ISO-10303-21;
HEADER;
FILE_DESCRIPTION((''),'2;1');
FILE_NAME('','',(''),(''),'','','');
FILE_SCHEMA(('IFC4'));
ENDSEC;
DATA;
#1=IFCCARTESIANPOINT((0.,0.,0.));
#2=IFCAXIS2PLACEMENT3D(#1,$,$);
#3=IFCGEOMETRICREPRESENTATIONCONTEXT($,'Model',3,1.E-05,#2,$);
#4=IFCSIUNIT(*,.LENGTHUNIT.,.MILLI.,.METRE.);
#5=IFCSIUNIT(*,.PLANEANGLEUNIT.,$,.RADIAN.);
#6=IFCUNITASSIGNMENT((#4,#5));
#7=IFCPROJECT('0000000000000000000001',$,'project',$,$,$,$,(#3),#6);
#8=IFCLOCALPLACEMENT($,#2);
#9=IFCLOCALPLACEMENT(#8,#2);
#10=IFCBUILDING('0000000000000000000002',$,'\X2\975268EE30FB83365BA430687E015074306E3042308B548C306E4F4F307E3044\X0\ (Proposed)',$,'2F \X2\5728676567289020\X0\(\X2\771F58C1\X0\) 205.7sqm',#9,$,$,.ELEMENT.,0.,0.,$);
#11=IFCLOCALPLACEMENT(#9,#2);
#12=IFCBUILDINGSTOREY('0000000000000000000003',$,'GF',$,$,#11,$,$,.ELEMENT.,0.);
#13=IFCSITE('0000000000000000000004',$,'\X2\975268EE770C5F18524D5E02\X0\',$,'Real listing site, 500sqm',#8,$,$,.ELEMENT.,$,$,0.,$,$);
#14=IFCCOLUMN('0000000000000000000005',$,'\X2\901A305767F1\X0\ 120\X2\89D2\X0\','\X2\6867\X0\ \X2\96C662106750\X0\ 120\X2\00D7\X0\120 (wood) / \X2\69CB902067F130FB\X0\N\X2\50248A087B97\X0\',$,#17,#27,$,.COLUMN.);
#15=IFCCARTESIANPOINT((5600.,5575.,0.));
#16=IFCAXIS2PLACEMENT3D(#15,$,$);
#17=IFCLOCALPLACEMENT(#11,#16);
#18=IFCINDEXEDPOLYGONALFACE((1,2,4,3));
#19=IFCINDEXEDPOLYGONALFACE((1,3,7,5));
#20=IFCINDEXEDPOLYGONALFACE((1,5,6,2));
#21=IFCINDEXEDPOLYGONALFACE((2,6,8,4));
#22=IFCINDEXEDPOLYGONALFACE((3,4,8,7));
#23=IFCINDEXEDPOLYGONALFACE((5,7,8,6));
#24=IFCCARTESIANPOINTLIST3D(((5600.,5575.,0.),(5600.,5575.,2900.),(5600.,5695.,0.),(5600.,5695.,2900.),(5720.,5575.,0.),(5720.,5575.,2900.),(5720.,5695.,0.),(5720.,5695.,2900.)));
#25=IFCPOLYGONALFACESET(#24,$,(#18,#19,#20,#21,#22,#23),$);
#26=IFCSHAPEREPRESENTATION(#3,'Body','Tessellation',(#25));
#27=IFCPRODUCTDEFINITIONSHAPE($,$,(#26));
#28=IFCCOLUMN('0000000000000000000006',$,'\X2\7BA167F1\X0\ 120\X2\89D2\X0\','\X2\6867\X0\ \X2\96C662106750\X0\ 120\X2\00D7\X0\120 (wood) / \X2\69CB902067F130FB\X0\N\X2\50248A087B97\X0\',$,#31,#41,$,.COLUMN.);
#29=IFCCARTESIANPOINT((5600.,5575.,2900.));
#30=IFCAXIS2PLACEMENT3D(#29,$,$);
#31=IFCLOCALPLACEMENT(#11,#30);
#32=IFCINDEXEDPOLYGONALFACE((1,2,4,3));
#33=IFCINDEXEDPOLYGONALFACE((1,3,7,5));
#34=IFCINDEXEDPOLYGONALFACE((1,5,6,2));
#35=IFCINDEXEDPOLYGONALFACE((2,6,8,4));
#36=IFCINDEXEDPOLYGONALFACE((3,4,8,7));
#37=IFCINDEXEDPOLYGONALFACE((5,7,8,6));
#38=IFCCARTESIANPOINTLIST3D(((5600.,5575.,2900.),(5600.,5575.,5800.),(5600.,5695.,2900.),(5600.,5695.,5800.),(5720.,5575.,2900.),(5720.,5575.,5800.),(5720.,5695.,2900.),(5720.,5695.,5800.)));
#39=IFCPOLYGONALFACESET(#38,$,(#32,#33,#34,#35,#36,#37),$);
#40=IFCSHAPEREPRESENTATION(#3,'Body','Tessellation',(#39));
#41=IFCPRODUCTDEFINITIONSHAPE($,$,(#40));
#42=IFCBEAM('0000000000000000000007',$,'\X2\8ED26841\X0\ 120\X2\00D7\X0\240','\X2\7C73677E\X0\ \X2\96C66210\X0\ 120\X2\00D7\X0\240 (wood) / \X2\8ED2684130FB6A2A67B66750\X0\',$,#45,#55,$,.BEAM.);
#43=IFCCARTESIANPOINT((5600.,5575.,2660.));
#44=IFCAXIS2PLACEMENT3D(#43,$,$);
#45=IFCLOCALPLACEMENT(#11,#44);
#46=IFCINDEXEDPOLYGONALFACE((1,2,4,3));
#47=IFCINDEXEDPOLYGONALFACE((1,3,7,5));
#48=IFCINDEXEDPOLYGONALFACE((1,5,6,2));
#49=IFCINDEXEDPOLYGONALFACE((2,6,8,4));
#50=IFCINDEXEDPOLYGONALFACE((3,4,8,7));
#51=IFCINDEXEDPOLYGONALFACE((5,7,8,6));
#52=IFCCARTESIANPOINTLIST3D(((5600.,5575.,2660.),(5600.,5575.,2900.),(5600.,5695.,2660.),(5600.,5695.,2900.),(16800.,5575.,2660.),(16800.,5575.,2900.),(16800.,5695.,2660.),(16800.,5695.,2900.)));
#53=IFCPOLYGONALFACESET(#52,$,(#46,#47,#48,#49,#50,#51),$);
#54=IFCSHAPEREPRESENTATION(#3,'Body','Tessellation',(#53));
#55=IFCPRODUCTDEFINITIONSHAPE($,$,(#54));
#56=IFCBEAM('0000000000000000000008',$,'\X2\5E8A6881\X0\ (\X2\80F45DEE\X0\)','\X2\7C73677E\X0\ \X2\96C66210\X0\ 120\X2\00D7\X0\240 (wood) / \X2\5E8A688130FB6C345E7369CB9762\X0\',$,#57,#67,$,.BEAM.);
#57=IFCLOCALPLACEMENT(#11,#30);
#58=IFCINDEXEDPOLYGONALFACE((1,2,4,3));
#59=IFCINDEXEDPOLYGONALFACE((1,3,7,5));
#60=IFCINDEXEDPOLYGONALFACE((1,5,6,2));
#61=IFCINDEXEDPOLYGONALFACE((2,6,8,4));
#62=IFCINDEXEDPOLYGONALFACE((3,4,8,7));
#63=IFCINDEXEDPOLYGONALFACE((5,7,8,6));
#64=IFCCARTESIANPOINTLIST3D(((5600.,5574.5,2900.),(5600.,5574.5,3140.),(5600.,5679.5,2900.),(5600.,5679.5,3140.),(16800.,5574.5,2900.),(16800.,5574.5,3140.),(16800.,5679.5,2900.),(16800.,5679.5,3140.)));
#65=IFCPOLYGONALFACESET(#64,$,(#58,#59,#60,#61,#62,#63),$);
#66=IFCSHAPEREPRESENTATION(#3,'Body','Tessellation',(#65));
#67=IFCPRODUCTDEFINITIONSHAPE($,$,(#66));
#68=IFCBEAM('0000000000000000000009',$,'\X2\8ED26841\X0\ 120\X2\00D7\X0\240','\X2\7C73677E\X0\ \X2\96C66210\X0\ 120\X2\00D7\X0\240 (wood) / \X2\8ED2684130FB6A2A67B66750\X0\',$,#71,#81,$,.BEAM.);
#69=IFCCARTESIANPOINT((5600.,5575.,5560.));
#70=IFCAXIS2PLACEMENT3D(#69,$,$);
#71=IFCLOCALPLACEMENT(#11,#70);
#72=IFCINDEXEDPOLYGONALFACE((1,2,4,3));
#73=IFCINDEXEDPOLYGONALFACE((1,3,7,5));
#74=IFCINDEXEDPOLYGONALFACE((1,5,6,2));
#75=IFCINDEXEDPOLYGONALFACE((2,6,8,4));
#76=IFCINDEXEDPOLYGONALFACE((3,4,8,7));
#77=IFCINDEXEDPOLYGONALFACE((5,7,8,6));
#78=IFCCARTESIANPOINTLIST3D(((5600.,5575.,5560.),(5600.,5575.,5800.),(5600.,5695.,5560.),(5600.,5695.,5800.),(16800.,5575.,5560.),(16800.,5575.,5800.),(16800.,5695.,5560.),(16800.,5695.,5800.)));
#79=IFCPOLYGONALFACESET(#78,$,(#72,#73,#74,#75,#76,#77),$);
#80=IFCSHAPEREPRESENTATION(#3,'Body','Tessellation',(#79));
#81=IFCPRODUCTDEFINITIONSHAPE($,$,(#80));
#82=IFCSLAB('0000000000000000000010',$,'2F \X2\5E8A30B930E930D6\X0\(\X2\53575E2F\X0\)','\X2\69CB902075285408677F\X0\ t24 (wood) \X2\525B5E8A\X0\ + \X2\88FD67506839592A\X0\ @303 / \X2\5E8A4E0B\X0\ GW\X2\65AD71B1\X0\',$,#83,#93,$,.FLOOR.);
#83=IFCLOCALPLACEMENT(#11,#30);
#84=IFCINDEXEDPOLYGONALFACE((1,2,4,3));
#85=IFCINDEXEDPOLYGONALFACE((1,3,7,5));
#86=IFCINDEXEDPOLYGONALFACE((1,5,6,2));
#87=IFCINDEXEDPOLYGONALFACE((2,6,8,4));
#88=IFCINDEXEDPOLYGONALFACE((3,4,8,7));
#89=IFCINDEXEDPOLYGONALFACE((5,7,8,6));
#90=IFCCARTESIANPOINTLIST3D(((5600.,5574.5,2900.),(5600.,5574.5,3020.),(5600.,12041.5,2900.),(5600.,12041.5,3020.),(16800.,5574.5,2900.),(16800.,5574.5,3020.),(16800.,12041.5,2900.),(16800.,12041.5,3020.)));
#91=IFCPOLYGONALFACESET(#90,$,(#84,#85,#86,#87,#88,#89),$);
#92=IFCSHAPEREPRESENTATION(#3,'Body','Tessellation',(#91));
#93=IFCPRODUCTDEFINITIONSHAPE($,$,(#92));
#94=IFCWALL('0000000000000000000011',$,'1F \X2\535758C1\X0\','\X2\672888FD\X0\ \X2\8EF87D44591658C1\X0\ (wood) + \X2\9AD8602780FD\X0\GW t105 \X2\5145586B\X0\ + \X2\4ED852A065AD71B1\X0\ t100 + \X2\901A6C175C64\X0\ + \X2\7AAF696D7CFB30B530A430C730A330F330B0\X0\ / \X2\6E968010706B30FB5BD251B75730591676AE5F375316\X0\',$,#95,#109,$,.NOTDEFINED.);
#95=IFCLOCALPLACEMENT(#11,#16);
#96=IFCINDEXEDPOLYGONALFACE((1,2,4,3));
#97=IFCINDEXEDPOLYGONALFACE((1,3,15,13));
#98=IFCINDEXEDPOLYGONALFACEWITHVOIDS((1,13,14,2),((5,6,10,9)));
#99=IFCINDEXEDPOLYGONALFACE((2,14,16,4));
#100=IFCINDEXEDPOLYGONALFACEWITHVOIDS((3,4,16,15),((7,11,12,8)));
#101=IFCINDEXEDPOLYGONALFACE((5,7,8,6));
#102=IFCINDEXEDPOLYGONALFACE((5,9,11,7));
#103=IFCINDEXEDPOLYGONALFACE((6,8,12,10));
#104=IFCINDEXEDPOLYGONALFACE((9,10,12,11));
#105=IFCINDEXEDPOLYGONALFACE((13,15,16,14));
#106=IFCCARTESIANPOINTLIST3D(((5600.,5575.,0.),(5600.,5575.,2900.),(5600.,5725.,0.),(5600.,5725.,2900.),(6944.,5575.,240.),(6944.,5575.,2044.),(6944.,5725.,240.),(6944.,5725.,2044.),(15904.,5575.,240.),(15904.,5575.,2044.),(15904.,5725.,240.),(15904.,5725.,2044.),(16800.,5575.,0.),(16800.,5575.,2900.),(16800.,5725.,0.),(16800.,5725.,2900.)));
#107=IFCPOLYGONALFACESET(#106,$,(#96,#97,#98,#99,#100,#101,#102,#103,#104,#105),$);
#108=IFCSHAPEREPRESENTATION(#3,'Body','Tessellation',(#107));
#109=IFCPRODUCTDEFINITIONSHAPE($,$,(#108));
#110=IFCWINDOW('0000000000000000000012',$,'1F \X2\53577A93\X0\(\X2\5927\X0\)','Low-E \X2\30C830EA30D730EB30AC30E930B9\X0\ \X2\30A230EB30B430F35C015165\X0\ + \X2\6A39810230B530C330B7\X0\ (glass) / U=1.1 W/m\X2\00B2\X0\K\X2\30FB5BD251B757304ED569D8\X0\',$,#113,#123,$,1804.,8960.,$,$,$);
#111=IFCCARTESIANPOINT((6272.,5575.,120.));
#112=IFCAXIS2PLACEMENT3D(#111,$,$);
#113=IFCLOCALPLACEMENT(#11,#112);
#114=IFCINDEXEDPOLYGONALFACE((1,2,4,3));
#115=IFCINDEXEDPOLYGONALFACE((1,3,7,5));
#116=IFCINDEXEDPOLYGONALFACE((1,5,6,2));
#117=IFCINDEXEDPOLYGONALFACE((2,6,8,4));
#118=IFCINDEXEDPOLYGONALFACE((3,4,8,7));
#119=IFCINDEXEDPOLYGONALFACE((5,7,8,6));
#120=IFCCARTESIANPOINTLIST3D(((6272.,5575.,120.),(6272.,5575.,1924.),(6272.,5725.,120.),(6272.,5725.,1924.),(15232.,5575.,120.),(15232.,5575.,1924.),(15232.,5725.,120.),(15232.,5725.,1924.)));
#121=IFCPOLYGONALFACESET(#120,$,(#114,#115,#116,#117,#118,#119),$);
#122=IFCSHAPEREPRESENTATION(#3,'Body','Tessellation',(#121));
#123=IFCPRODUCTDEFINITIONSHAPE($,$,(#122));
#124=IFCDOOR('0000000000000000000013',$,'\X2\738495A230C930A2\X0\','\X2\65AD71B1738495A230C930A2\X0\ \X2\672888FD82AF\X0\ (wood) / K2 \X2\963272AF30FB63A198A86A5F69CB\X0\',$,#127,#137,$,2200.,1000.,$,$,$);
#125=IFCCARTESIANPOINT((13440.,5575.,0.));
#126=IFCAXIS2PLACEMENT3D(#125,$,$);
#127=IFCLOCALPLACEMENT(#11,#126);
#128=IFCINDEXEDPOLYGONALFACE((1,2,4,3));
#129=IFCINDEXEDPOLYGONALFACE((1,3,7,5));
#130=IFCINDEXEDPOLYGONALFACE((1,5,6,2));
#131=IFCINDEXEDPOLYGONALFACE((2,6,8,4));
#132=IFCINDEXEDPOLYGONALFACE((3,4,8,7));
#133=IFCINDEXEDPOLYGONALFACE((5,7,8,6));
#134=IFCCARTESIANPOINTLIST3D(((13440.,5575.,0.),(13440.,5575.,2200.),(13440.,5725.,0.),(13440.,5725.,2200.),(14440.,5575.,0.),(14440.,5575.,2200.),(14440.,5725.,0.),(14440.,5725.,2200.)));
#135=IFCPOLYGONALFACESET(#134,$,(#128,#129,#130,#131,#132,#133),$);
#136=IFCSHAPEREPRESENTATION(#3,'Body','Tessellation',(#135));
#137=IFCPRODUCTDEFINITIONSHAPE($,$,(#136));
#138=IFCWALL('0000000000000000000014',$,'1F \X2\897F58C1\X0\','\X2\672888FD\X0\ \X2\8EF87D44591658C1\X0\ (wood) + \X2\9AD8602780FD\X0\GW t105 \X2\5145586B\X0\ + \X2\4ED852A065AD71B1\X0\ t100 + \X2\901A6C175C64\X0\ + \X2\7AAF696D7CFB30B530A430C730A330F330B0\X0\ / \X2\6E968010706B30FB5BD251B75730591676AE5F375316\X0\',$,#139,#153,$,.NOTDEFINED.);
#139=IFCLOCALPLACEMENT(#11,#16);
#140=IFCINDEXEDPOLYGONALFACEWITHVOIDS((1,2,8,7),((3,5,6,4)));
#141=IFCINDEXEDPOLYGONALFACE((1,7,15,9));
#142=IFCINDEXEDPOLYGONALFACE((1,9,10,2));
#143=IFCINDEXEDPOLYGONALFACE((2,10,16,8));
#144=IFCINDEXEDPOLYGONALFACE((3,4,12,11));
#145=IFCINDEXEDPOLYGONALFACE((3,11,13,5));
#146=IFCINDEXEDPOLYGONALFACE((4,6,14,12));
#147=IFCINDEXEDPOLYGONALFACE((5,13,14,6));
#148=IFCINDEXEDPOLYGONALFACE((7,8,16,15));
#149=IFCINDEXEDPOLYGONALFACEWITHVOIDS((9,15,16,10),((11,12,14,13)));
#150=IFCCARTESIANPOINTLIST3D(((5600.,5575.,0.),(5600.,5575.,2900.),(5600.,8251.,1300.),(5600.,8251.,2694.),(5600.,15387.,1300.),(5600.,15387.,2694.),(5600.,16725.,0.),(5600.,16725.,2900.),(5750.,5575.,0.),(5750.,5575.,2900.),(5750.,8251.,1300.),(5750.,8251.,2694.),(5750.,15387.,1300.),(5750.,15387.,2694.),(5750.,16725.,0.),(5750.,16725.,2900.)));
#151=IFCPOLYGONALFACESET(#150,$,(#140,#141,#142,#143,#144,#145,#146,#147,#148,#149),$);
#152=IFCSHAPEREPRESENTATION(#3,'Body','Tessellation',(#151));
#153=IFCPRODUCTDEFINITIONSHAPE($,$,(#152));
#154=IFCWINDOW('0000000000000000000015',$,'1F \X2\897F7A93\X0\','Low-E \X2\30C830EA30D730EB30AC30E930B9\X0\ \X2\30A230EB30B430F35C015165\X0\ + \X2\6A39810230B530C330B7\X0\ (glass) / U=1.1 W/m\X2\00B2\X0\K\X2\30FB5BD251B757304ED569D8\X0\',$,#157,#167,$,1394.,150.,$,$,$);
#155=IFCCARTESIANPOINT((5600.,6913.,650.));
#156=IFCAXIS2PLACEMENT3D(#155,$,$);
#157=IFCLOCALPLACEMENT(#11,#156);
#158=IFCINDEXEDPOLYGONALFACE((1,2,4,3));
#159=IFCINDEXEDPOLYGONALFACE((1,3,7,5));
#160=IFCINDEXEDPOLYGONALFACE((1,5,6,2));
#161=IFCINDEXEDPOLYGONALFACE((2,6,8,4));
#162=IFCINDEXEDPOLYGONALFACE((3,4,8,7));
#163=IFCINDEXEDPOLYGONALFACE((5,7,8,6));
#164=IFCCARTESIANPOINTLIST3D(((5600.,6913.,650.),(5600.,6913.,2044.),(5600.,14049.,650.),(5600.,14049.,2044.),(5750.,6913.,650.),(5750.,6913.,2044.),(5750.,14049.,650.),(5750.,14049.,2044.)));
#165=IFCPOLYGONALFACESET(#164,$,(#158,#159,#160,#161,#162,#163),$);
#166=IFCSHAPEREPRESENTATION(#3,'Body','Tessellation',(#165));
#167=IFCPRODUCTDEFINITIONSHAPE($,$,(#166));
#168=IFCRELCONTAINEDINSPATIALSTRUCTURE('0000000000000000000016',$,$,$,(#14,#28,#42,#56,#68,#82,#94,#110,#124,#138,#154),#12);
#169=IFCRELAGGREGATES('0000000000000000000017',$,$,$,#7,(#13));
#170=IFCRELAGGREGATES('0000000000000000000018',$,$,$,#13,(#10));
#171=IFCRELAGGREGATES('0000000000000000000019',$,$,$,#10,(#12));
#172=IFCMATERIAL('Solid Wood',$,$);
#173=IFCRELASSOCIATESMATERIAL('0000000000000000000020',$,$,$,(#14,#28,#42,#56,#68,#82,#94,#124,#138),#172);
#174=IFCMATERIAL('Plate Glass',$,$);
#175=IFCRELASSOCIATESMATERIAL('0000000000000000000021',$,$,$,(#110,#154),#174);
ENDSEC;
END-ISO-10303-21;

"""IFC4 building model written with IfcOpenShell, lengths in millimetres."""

from ifc_helpers import new_model, si_unit, frame, frame_2d, origin, place, context, project, spatial, rectangle, extrude, material, element, fill, save


model = new_model("IFC4")

# Units and contexts
model_context = context("Model", 3, precision=1e-05, world=origin())
ifc_project = project(units=[si_unit("LENGTHUNIT", "METRE", prefix="MILLI"), si_unit("PLANEANGLEUNIT", "RADIAN")], contexts=[model_context])

# Site, building, storey
site_placement = place(None, origin())
site = spatial("IfcSite", under=ifc_project, at=site_placement, Name="青森県弘前市", ObjectType="Real listing site, 500sqm", CompositionType="ELEMENT", RefElevation=0.0)
building_placement = place(site_placement, origin())
building = spatial("IfcBuilding", under=site, at=building_placement, Name="青森・茶室と縁側のある和の住まい (Proposed)", ObjectType="2F 在来木造(真壁) 205.7sqm", CompositionType="ELEMENT", ElevationOfRefHeight=0.0, ElevationOfTerrain=0.0)
storey_placement = place(building_placement, origin())
storey = spatial("IfcBuildingStorey", under=building, at=storey_placement, Name="GF", CompositionType="ELEMENT", Elevation=0.0)

# Columns
ifc_material_1 = material(Name="Solid Wood")
column_1_placement = place(storey_placement, frame((5600.0, 5575.0, 0.0)))
element("IfcColumn", 1, at=column_1_placement, inside=storey, material=ifc_material_1, Name="通し柱 120角", Description="桧 集成材 120×120 (wood) / 構造柱・N値計算", PredefinedType="COLUMN", context=model_context, shape_type="SweptSolid", body=[
    extrude(rectangle(XDim=120.0, YDim=120.0, at=frame_2d((60.0, 60.0))), frame((5600.0, 5575.0, 0.0)), (0.0, 0.0, 1.0), 2900.0),
])
column_2_placement = place(storey_placement, frame((5600.0, 5575.0, 2900.0)))
element("IfcColumn", 2, at=column_2_placement, inside=storey, material=ifc_material_1, Name="管柱 120角", Description="桧 集成材 120×120 (wood) / 構造柱・N値計算", PredefinedType="COLUMN", context=model_context, shape_type="SweptSolid", body=[
    extrude(rectangle(XDim=120.0, YDim=120.0, at=frame_2d((60.0, 60.0))), frame((5600.0, 5575.0, 2900.0)), (0.0, 0.0, 1.0), 2900.0),
])

# Beams
beam_1_placement = place(storey_placement, frame((5600.0, 5575.0, 2660.0)))
element("IfcBeam", 3, at=beam_1_placement, inside=storey, material=ifc_material_1, Name="軒桁 120×240", Description="米松 集成 120×240 (wood) / 軒桁・横架材", PredefinedType="BEAM", context=model_context, shape_type="SweptSolid", body=[
    extrude(rectangle(XDim=11200.0, YDim=120.0, at=frame_2d((5600.0, 60.0))), frame((5600.0, 5575.0, 2660.0)), (0.0, 0.0, 1.0), 240.0),
])
beam_2_placement = place(storey_placement, frame((5600.0, 5575.0, 2900.0)))
element("IfcBeam", 4, at=beam_2_placement, inside=storey, material=ifc_material_1, Name="床梁 (胴差)", Description="米松 集成 120×240 (wood) / 床梁・水平構面", PredefinedType="BEAM", context=model_context, shape_type="SweptSolid", body=[
    extrude(rectangle(XDim=11200.0, YDim=105.0, at=frame_2d((5600.0, 52.0))), frame((5600.0, 5575.0, 2900.0)), (0.0, 0.0, 1.0), 240.0),
])
beam_3_placement = place(storey_placement, frame((5600.0, 5575.0, 5560.0)))
element("IfcBeam", 5, at=beam_3_placement, inside=storey, material=ifc_material_1, Name="軒桁 120×240", Description="米松 集成 120×240 (wood) / 軒桁・横架材", PredefinedType="BEAM", context=model_context, shape_type="SweptSolid", body=[
    extrude(rectangle(XDim=11200.0, YDim=120.0, at=frame_2d((5600.0, 60.0))), frame((5600.0, 5575.0, 5560.0)), (0.0, 0.0, 1.0), 240.0),
])

# Slab
slab_1_placement = place(storey_placement, frame((5600.0, 5575.0, 2900.0)))
element("IfcSlab", 6, at=slab_1_placement, inside=storey, material=ifc_material_1, Name="2F 床スラブ(南帯)", Description="構造用合板 t24 (wood) 剛床 + 製材根太 @303 / 床下 GW断熱", PredefinedType="FLOOR", context=model_context, shape_type="SweptSolid", body=[
    extrude(rectangle(XDim=11200.0, YDim=6467.0, at=frame_2d((5600.0, 3233.0))), frame((5600.0, 5575.0, 2900.0)), (0.0, 0.0, 1.0), 120.0),
])

# Wall, openings, window, door
wall_1_placement = place(storey_placement, frame((5600.0, 5575.0, 0.0)))
wall_1 = element("IfcWall", 7, at=wall_1_placement, inside=storey, material=ifc_material_1, Name="1F 南壁", Description="木製 軸組外壁 (wood) + 高性能GW t105 充填 + 付加断熱 t100 + 通気層 + 窯業系サイディング / 準耐火・寒冷地外皮強化", PredefinedType="NOTDEFINED", context=model_context, shape_type="SweptSolid", body=[
    extrude(rectangle(XDim=11200.0, YDim=150.0, at=frame_2d((5600.0, 75.0))), frame((5600.0, 5575.0, 0.0)), (0.0, 0.0, 1.0), 2900.0),
])
opening_1_placement = place(storey_placement, frame((6272.0, 5575.0, 120.0)))
opening_1 = element("IfcOpeningElement", 8, at=opening_1_placement, cuts=wall_1, PredefinedType="NOTDEFINED", context=model_context, shape_type="SweptSolid", body=[
    extrude(rectangle(XDim=8960.0, YDim=150.0, at=frame_2d((4480.0, 75.0))), frame((6272.0, 5575.0, 120.0)), (0.0, 0.0, 1.0), 1804.0),
])
opening_2_placement = place(storey_placement, frame((13440.0, 5575.0, 0.0)))
opening_2 = element("IfcOpeningElement", 9, at=opening_2_placement, cuts=wall_1, PredefinedType="NOTDEFINED", context=model_context, shape_type="SweptSolid", body=[
    extrude(rectangle(XDim=1000.0, YDim=150.0, at=frame_2d((500.0, 75.0))), frame((13440.0, 5575.0, 0.0)), (0.0, 0.0, 1.0), 2200.0),
])
ifc_material_2 = material(Name="Plate Glass")
window_1_placement = place(storey_placement, frame((6272.0, 5575.0, 120.0)))
window_1 = element("IfcWindow", 10, at=window_1_placement, inside=storey, material=ifc_material_2, Name="1F 南窓(大)", Description="Low-E トリプルガラス アルゴン封入 + 樹脂サッシ (glass) / U=1.1 W/m²K・寒冷地仕様", OverallHeight=1804.0, OverallWidth=8960.0, context=model_context, shape_type="SweptSolid", body=[
    extrude(rectangle(XDim=8960.0, YDim=150.0, at=frame_2d((4480.0, 75.0))), frame((6272.0, 5575.0, 120.0)), (0.0, 0.0, 1.0), 1804.0),
])
fill(opening_1, window_1)
door_placement = place(storey_placement, frame((13440.0, 5575.0, 0.0)))
door = element("IfcDoor", 11, at=door_placement, inside=storey, material=ifc_material_1, Name="玄関ドア", Description="断熱玄関ドア 木製芯 (wood) / K2 防犯・採風機構", OverallHeight=2200.0, OverallWidth=1000.0, context=model_context, shape_type="SweptSolid", body=[
    extrude(rectangle(XDim=1000.0, YDim=150.0, at=frame_2d((500.0, 75.0))), frame((13440.0, 5575.0, 0.0)), (0.0, 0.0, 1.0), 2200.0),
])
fill(opening_2, door)

# Wall, opening, window
wall_2_placement = place(storey_placement, frame((5600.0, 5575.0, 0.0)))
wall_2 = element("IfcWall", 12, at=wall_2_placement, inside=storey, material=ifc_material_1, Name="1F 西壁", Description="木製 軸組外壁 (wood) + 高性能GW t105 充填 + 付加断熱 t100 + 通気層 + 窯業系サイディング / 準耐火・寒冷地外皮強化", PredefinedType="NOTDEFINED", context=model_context, shape_type="SweptSolid", body=[
    extrude(rectangle(XDim=150.0, YDim=11150.0, at=frame_2d((75.0, 5575.0))), frame((5600.0, 5575.0, 0.0)), (0.0, 0.0, 1.0), 2900.0),
])
opening_3_placement = place(storey_placement, frame((5600.0, 6913.0, 650.0)))
opening_3 = element("IfcOpeningElement", 13, at=opening_3_placement, cuts=wall_2, PredefinedType="NOTDEFINED", context=model_context, shape_type="SweptSolid", body=[
    extrude(rectangle(XDim=150.0, YDim=7136.0, at=frame_2d((75.0, 3568.0))), frame((5600.0, 6913.0, 650.0)), (0.0, 0.0, 1.0), 1394.0),
])
window_2_placement = place(storey_placement, frame((5600.0, 6913.0, 650.0)))
window_2 = element("IfcWindow", 14, at=window_2_placement, inside=storey, material=ifc_material_2, Name="1F 西窓", Description="Low-E トリプルガラス アルゴン封入 + 樹脂サッシ (glass) / U=1.1 W/m²K・寒冷地仕様", OverallHeight=1394.0, OverallWidth=150.0, context=model_context, shape_type="SweptSolid", body=[
    extrude(rectangle(XDim=150.0, YDim=7136.0, at=frame_2d((75.0, 3568.0))), frame((5600.0, 6913.0, 650.0)), (0.0, 0.0, 1.0), 1394.0),
])
fill(opening_3, window_2)

save(model, "model.ifc")
